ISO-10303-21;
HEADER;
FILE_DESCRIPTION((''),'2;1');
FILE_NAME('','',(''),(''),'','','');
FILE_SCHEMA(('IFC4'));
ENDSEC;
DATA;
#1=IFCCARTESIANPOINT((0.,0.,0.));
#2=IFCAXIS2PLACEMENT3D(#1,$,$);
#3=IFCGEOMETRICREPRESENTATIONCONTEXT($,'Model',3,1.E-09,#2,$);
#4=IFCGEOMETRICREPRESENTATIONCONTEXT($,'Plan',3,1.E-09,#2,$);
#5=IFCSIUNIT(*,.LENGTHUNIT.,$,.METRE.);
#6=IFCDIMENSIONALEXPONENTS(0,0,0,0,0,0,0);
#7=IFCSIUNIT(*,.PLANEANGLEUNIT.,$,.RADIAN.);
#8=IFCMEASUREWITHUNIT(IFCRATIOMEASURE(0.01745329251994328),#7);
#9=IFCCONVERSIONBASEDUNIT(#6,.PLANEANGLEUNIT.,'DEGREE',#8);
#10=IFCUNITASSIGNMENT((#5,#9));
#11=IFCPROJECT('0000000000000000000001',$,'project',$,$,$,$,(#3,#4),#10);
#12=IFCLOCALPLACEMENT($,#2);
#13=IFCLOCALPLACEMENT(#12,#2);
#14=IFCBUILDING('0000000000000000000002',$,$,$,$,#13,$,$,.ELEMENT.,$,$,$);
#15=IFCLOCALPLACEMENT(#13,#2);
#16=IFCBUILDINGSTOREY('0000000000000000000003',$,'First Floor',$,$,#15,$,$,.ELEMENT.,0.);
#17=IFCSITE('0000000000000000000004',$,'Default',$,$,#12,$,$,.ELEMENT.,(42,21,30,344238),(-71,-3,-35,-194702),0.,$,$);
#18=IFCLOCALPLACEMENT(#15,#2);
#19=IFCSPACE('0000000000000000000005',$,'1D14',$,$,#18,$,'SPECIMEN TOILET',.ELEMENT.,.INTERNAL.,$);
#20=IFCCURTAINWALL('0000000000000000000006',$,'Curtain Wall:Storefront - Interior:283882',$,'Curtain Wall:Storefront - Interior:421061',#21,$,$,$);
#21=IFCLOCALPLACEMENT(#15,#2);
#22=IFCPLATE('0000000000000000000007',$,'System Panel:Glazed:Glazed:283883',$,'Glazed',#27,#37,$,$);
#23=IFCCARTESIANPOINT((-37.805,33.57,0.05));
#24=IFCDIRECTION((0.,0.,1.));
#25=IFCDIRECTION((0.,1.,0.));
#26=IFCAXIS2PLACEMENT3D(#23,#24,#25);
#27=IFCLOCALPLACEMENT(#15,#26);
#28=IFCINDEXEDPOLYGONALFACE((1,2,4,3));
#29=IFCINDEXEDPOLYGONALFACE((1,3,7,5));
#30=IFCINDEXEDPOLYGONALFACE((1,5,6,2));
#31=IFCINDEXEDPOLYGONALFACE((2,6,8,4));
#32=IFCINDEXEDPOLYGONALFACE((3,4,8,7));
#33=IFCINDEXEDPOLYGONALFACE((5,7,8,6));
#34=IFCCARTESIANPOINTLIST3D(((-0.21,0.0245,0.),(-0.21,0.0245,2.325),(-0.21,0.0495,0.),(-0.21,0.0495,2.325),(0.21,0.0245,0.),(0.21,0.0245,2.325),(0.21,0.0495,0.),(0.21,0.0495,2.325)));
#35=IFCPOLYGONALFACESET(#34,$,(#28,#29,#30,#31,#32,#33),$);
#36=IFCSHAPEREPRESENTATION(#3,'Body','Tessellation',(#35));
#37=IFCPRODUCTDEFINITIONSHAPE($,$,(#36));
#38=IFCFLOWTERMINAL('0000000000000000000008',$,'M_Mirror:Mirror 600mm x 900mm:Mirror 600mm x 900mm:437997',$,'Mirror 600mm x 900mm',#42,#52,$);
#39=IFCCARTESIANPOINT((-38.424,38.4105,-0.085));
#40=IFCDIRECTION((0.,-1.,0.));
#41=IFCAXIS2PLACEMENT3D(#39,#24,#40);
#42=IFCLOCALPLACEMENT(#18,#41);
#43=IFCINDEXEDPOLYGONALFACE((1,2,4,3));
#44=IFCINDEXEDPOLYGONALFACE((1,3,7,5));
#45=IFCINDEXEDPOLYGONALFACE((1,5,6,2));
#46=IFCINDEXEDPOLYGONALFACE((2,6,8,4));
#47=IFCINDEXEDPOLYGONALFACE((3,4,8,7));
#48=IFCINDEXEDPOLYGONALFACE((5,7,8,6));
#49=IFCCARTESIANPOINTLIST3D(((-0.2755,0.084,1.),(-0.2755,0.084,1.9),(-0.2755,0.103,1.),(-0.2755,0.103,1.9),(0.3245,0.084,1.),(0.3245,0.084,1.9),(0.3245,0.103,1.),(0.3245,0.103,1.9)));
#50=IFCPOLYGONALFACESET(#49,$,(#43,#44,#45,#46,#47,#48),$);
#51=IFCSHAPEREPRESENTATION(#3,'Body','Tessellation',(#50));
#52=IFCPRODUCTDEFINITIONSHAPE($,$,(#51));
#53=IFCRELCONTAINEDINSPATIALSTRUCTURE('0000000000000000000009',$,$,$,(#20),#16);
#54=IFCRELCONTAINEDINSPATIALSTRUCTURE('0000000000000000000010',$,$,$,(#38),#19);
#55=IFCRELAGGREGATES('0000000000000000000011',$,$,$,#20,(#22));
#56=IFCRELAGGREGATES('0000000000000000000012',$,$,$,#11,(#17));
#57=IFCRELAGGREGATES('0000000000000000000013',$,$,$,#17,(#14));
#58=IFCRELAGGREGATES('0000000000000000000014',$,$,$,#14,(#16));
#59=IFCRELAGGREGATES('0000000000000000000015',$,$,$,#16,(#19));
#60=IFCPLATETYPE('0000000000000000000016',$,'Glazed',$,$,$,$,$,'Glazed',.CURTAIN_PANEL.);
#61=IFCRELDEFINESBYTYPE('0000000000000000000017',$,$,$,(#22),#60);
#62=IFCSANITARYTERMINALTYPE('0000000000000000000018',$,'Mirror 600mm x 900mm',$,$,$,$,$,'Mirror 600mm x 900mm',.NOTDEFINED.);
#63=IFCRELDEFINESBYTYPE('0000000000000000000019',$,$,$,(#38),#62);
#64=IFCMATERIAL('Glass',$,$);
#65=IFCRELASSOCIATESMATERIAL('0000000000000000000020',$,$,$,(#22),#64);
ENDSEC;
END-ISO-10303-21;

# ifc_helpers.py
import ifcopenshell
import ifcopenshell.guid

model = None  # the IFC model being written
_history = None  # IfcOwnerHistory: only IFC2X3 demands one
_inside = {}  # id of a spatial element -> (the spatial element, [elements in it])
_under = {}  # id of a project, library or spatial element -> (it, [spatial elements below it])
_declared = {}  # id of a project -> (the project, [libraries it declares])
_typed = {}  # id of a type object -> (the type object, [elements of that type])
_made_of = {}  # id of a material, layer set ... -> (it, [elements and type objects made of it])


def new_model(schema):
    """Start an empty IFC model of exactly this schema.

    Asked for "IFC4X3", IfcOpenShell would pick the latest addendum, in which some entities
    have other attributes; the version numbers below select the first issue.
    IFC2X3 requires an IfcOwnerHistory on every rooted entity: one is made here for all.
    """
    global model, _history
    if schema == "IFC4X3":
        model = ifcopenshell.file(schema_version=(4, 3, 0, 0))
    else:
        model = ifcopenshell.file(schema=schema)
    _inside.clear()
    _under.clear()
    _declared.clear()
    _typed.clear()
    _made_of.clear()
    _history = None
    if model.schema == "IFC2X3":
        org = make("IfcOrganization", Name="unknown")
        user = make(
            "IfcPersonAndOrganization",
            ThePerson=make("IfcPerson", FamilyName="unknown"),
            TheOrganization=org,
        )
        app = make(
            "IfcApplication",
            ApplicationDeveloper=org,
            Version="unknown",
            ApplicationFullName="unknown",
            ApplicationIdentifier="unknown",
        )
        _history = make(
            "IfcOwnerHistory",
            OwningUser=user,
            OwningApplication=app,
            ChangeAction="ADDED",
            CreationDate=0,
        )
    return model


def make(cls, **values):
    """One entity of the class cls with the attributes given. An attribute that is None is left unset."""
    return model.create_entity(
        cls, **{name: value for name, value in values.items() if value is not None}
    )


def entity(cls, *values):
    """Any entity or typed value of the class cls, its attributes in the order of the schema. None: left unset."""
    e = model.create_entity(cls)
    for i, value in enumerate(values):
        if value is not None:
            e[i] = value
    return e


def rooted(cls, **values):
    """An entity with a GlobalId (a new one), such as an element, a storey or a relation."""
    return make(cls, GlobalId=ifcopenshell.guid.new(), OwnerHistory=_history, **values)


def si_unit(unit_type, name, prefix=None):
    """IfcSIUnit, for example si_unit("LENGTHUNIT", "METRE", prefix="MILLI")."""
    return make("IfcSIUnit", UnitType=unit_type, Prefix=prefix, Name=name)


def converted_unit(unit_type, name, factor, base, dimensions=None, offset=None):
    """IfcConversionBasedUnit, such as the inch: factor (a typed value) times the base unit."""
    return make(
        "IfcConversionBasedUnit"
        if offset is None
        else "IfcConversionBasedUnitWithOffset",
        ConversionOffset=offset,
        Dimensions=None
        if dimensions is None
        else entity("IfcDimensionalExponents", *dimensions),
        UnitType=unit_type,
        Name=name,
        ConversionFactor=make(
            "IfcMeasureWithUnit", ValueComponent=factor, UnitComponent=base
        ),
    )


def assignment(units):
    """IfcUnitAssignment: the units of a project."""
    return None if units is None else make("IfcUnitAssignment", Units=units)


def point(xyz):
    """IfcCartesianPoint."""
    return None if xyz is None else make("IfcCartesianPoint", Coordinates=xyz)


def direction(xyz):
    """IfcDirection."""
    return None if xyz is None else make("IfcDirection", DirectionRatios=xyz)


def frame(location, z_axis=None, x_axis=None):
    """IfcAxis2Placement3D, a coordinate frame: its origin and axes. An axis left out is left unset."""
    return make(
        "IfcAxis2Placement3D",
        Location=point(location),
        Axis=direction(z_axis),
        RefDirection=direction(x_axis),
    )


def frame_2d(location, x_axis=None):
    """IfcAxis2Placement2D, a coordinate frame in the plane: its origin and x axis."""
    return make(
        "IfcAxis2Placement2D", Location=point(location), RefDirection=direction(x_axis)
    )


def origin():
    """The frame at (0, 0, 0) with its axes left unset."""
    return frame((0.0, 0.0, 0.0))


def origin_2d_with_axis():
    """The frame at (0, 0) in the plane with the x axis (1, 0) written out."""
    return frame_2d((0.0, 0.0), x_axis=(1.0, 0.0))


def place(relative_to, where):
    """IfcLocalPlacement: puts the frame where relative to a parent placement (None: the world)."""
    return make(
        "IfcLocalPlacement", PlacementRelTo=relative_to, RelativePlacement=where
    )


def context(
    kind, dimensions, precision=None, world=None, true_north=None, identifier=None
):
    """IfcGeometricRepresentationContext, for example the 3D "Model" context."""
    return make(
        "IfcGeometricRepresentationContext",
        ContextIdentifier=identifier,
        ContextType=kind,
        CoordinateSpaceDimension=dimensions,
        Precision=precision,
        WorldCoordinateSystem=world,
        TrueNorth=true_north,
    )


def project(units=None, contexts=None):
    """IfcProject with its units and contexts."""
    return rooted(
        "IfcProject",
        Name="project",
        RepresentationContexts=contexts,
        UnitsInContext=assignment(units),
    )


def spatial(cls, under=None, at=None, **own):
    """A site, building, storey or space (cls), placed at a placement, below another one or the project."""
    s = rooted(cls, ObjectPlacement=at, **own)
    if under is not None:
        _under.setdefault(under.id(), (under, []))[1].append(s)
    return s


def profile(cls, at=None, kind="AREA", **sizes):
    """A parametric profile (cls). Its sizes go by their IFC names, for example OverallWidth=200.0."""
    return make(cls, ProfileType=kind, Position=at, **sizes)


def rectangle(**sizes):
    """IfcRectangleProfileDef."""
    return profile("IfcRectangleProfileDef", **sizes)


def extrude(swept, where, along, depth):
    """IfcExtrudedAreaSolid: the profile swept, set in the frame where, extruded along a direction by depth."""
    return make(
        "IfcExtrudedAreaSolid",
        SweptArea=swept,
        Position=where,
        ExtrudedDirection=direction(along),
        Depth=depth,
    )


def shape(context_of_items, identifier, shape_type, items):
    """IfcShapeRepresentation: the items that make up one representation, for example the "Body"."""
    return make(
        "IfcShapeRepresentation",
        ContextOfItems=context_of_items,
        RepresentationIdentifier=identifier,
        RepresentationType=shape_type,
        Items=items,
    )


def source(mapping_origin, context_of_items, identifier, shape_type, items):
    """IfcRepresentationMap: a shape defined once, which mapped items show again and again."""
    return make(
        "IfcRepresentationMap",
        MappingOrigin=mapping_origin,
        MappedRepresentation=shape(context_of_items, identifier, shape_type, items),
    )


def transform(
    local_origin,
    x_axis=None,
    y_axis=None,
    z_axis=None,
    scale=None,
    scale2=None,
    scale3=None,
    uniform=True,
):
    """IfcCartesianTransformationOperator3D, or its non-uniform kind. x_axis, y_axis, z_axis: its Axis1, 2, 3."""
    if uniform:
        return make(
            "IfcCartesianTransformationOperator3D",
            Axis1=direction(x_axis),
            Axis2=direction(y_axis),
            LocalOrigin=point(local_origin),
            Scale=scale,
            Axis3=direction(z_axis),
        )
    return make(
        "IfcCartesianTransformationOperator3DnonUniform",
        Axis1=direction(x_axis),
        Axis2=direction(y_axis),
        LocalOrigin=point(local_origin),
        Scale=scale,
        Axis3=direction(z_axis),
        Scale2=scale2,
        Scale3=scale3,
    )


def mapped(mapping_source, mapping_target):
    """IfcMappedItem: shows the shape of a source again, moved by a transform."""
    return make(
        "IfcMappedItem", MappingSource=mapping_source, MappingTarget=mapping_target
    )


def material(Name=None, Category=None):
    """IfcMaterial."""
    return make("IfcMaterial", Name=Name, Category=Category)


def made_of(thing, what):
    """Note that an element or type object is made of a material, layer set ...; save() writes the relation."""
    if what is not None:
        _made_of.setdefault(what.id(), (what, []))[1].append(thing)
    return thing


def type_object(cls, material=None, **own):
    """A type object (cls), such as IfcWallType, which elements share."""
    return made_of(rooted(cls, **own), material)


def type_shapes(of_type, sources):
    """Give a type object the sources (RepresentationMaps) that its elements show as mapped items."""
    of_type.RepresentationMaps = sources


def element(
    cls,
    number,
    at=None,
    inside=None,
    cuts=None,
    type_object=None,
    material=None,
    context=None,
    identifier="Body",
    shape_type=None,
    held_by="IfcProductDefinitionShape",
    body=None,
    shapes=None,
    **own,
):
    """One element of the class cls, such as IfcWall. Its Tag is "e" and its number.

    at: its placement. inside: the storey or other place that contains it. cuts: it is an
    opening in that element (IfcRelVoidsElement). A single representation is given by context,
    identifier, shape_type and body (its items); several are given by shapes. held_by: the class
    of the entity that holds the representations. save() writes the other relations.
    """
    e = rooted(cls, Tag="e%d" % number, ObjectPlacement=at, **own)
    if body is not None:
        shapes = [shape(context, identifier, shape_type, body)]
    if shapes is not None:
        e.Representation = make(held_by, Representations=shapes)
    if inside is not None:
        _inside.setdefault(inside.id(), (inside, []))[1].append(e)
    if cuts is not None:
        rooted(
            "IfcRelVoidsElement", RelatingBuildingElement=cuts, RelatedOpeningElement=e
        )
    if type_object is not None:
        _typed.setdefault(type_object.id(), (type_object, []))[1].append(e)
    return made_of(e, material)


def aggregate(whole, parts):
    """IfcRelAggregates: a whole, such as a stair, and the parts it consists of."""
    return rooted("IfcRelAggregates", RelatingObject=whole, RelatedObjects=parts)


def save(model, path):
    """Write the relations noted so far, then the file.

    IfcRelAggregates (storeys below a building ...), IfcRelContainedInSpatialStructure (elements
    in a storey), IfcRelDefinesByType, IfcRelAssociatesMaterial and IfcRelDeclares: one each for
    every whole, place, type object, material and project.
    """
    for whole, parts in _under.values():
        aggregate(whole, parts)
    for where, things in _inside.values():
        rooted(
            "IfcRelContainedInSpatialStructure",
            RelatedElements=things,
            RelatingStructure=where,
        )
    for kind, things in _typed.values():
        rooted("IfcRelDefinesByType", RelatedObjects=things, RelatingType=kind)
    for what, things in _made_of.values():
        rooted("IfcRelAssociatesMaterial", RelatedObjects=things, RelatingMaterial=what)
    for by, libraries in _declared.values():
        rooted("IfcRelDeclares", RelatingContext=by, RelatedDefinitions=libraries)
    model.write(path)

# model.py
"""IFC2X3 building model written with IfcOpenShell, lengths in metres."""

from ifc_helpers import new_model, entity, si_unit, converted_unit, frame, origin, origin_2d_with_axis, place, context, project, spatial, rectangle, extrude, source, transform, mapped, material, type_object, type_shapes, element, aggregate, save


model = new_model("IFC2X3")

# Units and contexts
model_context = context("Model", 3, precision=1e-09, world=origin())
plan_context = context("Plan", 3, precision=1e-09, world=origin())
ifc_project = project(units=[si_unit("LENGTHUNIT", "METRE"), converted_unit("PLANEANGLEUNIT", "DEGREE", entity("IfcRatioMeasure", 0.01745329251994328), si_unit("PLANEANGLEUNIT", "RADIAN"), dimensions=[0, 0, 0, 0, 0, 0, 0])], contexts=[model_context, plan_context])

# Site, building, storey
site_placement = place(None, origin())
site = spatial("IfcSite", under=ifc_project, at=site_placement, Name="Default", CompositionType="ELEMENT", RefLatitude=(42, 21, 30, 344238), RefLongitude=(-71, -3, -35, -194702), RefElevation=0.0)
building_placement = place(site_placement, origin())
building = spatial("IfcBuilding", under=site, at=building_placement, CompositionType="ELEMENT")
storey_placement = place(building_placement, origin())
storey = spatial("IfcBuildingStorey", under=building, at=storey_placement, Name="First Floor", CompositionType="ELEMENT", Elevation=0.0)

# Curtain wall
curtain_wall_1_placement = place(storey_placement, origin())
curtain_wall_1 = element("IfcCurtainWall", 1, at=curtain_wall_1_placement, inside=storey, Name="Curtain Wall:Storefront - Interior:283882", ObjectType="Curtain Wall:Storefront - Interior:421061")

# Plate
ifc_material_1 = material(Name="Glass")
plate_type_1 = type_object("IfcPlateType", Name="Glazed", ElementType="Glazed", PredefinedType="CURTAIN_PANEL")
shared_shape_1 = source(origin(), model_context, "Body", "SweptSolid", [
    extrude(rectangle(XDim=0.025, YDim=0.42, at=origin_2d_with_axis()), frame((0.0, 0.037, 0.0), z_axis=(0.0, 0.0, 1.0), x_axis=(0.0, 1.0, 0.0)), (0.0, 0.0, 1.0), 2.325),
])
type_shapes(plate_type_1, [shared_shape_1])
plate_1_placement = place(storey_placement, frame((-37.805, 33.57, 0.05), z_axis=(0.0, 0.0, 1.0), x_axis=(0.0, 1.0, 0.0)))
plate_1 = element("IfcPlate", 2, at=plate_1_placement, type_object=plate_type_1, material=ifc_material_1, Name="System Panel:Glazed:Glazed:283883", ObjectType="Glazed", context=model_context, shape_type="MappedRepresentation", body=[
    mapped(shared_shape_1, transform((0.0, 0.0, 0.0), scale=1.0)),
])

aggregate(curtain_wall_1, [plate_1])

# Shared definitions
space_placement = place(storey_placement, origin())
space = spatial("IfcSpace", under=storey, at=space_placement, Name="1D14", LongName="SPECIMEN TOILET", CompositionType="ELEMENT", InteriorOrExteriorSpace="INTERNAL")

# Flow terminal
sanitary_terminal_type = type_object("IfcSanitaryTerminalType", Name="Mirror 600mm x 900mm", ElementType="Mirror 600mm x 900mm", PredefinedType="NOTDEFINED")
shared_shape_2 = source(origin(), model_context, "Body", "SweptSolid", [
    extrude(rectangle(XDim=0.0191, YDim=0.6, at=origin_2d_with_axis()), frame((0.0245, 0.0935, 1.0), z_axis=(0.0, 0.0, 1.0), x_axis=(0.0, -1.0, 0.0)), (0.0, 0.0, 1.0), 0.9),
])
type_shapes(sanitary_terminal_type, [shared_shape_2])
flow_terminal_placement = place(space_placement, frame((-38.424, 38.4105, -0.085), z_axis=(0.0, 0.0, 1.0), x_axis=(0.0, -1.0, 0.0)))
element("IfcFlowTerminal", 3, at=flow_terminal_placement, inside=space, type_object=sanitary_terminal_type, Name="M_Mirror:Mirror 600mm x 900mm:Mirror 600mm x 900mm:437997", ObjectType="Mirror 600mm x 900mm", context=model_context, shape_type="MappedRepresentation", body=[
    mapped(shared_shape_2, transform((0.0, 0.0, 0.0), scale=1.0)),
])

save(model, "model.ifc")
